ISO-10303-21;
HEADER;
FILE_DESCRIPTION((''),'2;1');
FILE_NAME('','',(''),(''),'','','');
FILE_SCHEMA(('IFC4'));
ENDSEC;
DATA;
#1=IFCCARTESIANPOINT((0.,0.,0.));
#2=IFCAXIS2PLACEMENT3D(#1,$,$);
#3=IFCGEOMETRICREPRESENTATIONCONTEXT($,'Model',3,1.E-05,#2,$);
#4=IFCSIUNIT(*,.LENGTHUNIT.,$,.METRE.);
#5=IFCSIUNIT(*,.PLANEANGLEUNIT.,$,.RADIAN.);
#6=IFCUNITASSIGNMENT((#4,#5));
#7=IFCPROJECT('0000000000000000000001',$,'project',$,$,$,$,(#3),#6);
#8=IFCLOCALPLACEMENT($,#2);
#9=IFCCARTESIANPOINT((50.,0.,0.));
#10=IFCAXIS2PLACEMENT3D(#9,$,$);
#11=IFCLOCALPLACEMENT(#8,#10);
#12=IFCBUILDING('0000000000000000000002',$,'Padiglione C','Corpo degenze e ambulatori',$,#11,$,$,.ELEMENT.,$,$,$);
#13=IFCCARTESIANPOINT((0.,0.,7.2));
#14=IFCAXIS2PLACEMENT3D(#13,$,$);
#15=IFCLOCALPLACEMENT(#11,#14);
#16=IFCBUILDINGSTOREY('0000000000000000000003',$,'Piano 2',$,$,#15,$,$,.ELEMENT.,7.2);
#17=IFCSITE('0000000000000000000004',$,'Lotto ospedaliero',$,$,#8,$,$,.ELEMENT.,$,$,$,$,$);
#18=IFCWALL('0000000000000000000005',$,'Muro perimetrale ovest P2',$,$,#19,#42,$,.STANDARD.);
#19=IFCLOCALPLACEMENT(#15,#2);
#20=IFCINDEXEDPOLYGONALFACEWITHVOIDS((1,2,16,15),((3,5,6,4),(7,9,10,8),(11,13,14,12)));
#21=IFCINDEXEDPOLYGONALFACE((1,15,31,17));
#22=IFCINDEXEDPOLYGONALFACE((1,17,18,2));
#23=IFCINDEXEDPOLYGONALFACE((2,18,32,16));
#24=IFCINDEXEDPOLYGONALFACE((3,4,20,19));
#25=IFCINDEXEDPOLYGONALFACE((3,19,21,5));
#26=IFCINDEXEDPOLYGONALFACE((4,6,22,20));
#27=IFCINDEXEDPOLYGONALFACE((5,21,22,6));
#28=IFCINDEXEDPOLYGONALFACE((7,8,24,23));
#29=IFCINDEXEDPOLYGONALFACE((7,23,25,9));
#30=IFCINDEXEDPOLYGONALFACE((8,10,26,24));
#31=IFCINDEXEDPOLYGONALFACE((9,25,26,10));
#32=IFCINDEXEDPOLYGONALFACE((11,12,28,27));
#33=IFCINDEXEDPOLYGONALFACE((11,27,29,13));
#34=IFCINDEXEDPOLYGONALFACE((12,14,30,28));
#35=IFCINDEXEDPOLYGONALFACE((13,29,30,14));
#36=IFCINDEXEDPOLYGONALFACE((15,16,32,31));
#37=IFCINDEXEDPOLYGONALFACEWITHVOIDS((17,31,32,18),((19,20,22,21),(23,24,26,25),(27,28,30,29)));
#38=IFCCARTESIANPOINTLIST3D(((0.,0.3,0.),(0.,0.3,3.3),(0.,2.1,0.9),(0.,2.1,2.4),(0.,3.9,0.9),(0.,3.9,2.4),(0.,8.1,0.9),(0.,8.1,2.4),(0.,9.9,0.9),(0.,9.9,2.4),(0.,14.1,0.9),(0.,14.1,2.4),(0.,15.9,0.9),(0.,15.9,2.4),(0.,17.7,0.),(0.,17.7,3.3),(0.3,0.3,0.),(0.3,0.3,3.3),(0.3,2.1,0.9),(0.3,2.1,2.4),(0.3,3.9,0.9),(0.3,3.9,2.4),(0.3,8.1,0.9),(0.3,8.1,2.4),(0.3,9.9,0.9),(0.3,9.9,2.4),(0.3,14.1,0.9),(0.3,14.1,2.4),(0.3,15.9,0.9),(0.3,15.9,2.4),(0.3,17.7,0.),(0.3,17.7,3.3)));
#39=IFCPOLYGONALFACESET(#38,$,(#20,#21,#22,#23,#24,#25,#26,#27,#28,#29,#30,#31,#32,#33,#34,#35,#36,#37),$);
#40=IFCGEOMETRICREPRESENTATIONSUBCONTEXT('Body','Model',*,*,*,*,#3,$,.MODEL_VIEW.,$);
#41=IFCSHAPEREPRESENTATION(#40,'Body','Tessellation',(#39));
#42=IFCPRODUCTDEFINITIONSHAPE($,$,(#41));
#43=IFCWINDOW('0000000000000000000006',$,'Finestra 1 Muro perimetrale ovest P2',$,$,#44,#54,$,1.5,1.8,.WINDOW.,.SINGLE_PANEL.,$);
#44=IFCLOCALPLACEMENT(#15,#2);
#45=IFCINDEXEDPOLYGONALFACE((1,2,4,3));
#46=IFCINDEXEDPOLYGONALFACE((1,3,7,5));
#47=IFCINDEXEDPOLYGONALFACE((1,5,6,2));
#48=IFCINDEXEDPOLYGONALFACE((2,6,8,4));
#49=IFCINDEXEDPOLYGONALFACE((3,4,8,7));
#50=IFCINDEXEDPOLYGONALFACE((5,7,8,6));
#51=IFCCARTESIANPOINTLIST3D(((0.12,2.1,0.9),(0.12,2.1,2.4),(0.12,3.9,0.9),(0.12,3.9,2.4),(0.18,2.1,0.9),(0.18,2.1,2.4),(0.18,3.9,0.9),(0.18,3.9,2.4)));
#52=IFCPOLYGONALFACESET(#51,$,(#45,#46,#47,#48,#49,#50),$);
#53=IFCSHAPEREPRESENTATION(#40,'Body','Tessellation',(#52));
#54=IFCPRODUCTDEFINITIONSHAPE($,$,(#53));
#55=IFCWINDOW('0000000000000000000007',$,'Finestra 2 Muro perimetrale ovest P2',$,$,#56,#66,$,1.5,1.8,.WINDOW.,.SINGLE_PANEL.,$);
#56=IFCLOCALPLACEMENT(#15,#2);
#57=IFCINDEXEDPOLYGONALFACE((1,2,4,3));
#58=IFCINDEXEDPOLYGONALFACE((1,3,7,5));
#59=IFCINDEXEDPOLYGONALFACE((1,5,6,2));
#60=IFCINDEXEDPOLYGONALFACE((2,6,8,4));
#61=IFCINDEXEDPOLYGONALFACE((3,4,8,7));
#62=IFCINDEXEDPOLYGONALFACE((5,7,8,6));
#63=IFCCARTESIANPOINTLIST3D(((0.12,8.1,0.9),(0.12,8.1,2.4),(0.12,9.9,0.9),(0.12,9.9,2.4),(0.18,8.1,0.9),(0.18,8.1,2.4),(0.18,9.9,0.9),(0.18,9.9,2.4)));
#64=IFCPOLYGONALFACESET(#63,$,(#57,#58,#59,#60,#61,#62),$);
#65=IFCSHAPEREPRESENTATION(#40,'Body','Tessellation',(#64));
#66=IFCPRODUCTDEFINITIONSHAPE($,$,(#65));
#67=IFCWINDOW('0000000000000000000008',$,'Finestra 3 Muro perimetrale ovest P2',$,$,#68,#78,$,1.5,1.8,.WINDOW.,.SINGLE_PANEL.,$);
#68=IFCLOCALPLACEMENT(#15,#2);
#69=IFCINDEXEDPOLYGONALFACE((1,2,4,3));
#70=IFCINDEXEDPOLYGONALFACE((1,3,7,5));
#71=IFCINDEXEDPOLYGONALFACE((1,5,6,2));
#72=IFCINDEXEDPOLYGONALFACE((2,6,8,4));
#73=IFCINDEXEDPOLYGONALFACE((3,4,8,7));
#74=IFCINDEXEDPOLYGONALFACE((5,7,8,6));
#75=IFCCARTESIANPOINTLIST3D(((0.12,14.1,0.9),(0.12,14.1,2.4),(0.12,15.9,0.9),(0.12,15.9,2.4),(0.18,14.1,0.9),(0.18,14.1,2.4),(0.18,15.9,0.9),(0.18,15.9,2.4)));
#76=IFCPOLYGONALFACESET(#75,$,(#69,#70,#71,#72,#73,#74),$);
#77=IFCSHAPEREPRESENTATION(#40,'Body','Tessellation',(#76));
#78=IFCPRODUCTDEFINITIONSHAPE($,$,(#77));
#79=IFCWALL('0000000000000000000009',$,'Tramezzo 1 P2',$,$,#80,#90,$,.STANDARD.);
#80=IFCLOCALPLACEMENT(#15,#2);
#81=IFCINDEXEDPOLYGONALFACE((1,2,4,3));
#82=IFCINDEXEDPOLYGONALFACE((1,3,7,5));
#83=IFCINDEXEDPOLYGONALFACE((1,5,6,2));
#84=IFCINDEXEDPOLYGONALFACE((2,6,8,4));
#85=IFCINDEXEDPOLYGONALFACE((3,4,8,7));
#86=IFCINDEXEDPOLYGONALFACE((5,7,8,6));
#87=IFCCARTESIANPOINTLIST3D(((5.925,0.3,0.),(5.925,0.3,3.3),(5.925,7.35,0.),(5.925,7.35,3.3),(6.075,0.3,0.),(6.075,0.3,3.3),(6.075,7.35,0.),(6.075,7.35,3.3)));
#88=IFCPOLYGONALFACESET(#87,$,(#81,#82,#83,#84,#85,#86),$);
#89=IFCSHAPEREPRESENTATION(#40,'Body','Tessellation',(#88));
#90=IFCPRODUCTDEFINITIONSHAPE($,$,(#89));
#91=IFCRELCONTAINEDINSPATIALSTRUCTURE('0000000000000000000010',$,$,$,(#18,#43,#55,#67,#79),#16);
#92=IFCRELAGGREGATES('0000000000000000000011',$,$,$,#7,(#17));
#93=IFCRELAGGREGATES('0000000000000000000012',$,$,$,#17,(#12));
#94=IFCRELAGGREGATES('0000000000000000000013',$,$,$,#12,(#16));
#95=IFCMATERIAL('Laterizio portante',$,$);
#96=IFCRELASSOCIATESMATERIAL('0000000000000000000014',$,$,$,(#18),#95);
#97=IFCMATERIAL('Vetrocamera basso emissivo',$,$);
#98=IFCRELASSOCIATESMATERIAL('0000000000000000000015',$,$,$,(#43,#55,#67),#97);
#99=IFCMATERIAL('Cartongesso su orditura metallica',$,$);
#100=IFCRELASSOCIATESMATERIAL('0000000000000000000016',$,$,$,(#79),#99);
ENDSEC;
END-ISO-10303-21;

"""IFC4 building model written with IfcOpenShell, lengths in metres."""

from ifc_helpers import new_model, si_unit, frame, frame_2d, origin, place, context, subcontext, project, spatial, rectangle, extrude, material, element, fill, save


model = new_model("IFC4")

# Units and contexts
model_context = context("Model", 3, precision=1e-05, world=origin())
body_context = subcontext(model_context, "Body", "Model", "MODEL_VIEW")
ifc_project = project(units=[si_unit("LENGTHUNIT", "METRE"), si_unit("PLANEANGLEUNIT", "RADIAN")], contexts=[model_context])

# Site, building, storey
site_placement = place(None, origin())
site = spatial("IfcSite", under=ifc_project, at=site_placement, Name="Lotto ospedaliero", CompositionType="ELEMENT")
building_placement = place(site_placement, frame((50.0, 0.0, 0.0)))
building = spatial("IfcBuilding", under=site, at=building_placement, Name="Padiglione C", Description="Corpo degenze e ambulatori", CompositionType="ELEMENT")
storey_placement = place(building_placement, frame((0.0, 0.0, 7.2)))
storey = spatial("IfcBuildingStorey", under=building, at=storey_placement, Name="Piano 2", CompositionType="ELEMENT", Elevation=7.2)

# Wall, openings, windows
ifc_material_1 = material(Name="Laterizio portante")
ifc_material_2 = material(Name="Vetrocamera basso emissivo")
wall_1_placement = place(storey_placement, frame((0.0, 0.3, 0.0)))
wall_1 = element("IfcWall", 1, at=wall_1_placement, inside=storey, material=ifc_material_1, Name="Muro perimetrale ovest P2", PredefinedType="STANDARD", context=body_context, shape_type="SweptSolid", body=[
    extrude(rectangle(XDim=0.3, YDim=17.4, at=frame_2d((0.15, 8.7))), origin(), (0.0, 0.0, 1.0), 3.3),
])
opening_1_placement = place(wall_1_placement, frame((-0.1, 1.8, 0.9)))
opening_1 = element("IfcOpeningElement", 2, at=opening_1_placement, cuts=wall_1, PredefinedType="OPENING", context=body_context, shape_type="SweptSolid", body=[
    extrude(rectangle(XDim=0.5, YDim=1.8, at=frame_2d((0.25, 0.9))), origin(), (0.0, 0.0, 1.0), 1.5),
])
opening_2_placement = place(wall_1_placement, frame((-0.1, 7.8, 0.9)))
opening_2 = element("IfcOpeningElement", 3, at=opening_2_placement, cuts=wall_1, PredefinedType="OPENING", context=body_context, shape_type="SweptSolid", body=[
    extrude(rectangle(XDim=0.5, YDim=1.8, at=frame_2d((0.25, 0.9))), origin(), (0.0, 0.0, 1.0), 1.5),
])
opening_3_placement = place(wall_1_placement, frame((-0.1, 13.8, 0.9)))
opening_3 = element("IfcOpeningElement", 4, at=opening_3_placement, cuts=wall_1, PredefinedType="OPENING", context=body_context, shape_type="SweptSolid", body=[
    extrude(rectangle(XDim=0.5, YDim=1.8, at=frame_2d((0.25, 0.9))), origin(), (0.0, 0.0, 1.0), 1.5),
])
window_1_placement = place(wall_1_placement, frame((0.12, 1.8, 0.9)))
window_1 = element("IfcWindow", 5, at=window_1_placement, inside=storey, material=ifc_material_2, Name="Finestra 1 Muro perimetrale ovest P2", OverallHeight=1.5, OverallWidth=1.8, PartitioningType="SINGLE_PANEL", PredefinedType="WINDOW", context=body_context, shape_type="SweptSolid", body=[
    extrude(rectangle(XDim=0.06, YDim=1.8, at=frame_2d((0.03, 0.9))), origin(), (0.0, 0.0, 1.0), 1.5),
])
fill(opening_1, window_1)
window_2_placement = place(wall_1_placement, frame((0.12, 7.8, 0.9)))
window_2 = element("IfcWindow", 6, at=window_2_placement, inside=storey, material=ifc_material_2, Name="Finestra 2 Muro perimetrale ovest P2", OverallHeight=1.5, OverallWidth=1.8, PartitioningType="SINGLE_PANEL", PredefinedType="WINDOW", context=body_context, shape_type="SweptSolid", body=[
    extrude(rectangle(XDim=0.06, YDim=1.8, at=frame_2d((0.03, 0.9))), origin(), (0.0, 0.0, 1.0), 1.5),
])
fill(opening_2, window_2)
window_3_placement = place(wall_1_placement, frame((0.12, 13.8, 0.9)))
window_3 = element("IfcWindow", 7, at=window_3_placement, inside=storey, material=ifc_material_2, Name="Finestra 3 Muro perimetrale ovest P2", OverallHeight=1.5, OverallWidth=1.8, PartitioningType="SINGLE_PANEL", PredefinedType="WINDOW", context=body_context, shape_type="SweptSolid", body=[
    extrude(rectangle(XDim=0.06, YDim=1.8, at=frame_2d((0.03, 0.9))), origin(), (0.0, 0.0, 1.0), 1.5),
])
fill(opening_3, window_3)

# Wall
ifc_material_3 = material(Name="Cartongesso su orditura metallica")
wall_2_placement = place(storey_placement, frame((5.925, 0.3, 0.0)))
element("IfcWall", 8, at=wall_2_placement, inside=storey, material=ifc_material_3, Name="Tramezzo 1 P2", PredefinedType="STANDARD", context=body_context, shape_type="SweptSolid", body=[
    extrude(rectangle(XDim=0.15, YDim=7.05, at=frame_2d((0.075, 3.525))), origin(), (0.0, 0.0, 1.0), 3.3),
])

save(model, "model.ifc")
